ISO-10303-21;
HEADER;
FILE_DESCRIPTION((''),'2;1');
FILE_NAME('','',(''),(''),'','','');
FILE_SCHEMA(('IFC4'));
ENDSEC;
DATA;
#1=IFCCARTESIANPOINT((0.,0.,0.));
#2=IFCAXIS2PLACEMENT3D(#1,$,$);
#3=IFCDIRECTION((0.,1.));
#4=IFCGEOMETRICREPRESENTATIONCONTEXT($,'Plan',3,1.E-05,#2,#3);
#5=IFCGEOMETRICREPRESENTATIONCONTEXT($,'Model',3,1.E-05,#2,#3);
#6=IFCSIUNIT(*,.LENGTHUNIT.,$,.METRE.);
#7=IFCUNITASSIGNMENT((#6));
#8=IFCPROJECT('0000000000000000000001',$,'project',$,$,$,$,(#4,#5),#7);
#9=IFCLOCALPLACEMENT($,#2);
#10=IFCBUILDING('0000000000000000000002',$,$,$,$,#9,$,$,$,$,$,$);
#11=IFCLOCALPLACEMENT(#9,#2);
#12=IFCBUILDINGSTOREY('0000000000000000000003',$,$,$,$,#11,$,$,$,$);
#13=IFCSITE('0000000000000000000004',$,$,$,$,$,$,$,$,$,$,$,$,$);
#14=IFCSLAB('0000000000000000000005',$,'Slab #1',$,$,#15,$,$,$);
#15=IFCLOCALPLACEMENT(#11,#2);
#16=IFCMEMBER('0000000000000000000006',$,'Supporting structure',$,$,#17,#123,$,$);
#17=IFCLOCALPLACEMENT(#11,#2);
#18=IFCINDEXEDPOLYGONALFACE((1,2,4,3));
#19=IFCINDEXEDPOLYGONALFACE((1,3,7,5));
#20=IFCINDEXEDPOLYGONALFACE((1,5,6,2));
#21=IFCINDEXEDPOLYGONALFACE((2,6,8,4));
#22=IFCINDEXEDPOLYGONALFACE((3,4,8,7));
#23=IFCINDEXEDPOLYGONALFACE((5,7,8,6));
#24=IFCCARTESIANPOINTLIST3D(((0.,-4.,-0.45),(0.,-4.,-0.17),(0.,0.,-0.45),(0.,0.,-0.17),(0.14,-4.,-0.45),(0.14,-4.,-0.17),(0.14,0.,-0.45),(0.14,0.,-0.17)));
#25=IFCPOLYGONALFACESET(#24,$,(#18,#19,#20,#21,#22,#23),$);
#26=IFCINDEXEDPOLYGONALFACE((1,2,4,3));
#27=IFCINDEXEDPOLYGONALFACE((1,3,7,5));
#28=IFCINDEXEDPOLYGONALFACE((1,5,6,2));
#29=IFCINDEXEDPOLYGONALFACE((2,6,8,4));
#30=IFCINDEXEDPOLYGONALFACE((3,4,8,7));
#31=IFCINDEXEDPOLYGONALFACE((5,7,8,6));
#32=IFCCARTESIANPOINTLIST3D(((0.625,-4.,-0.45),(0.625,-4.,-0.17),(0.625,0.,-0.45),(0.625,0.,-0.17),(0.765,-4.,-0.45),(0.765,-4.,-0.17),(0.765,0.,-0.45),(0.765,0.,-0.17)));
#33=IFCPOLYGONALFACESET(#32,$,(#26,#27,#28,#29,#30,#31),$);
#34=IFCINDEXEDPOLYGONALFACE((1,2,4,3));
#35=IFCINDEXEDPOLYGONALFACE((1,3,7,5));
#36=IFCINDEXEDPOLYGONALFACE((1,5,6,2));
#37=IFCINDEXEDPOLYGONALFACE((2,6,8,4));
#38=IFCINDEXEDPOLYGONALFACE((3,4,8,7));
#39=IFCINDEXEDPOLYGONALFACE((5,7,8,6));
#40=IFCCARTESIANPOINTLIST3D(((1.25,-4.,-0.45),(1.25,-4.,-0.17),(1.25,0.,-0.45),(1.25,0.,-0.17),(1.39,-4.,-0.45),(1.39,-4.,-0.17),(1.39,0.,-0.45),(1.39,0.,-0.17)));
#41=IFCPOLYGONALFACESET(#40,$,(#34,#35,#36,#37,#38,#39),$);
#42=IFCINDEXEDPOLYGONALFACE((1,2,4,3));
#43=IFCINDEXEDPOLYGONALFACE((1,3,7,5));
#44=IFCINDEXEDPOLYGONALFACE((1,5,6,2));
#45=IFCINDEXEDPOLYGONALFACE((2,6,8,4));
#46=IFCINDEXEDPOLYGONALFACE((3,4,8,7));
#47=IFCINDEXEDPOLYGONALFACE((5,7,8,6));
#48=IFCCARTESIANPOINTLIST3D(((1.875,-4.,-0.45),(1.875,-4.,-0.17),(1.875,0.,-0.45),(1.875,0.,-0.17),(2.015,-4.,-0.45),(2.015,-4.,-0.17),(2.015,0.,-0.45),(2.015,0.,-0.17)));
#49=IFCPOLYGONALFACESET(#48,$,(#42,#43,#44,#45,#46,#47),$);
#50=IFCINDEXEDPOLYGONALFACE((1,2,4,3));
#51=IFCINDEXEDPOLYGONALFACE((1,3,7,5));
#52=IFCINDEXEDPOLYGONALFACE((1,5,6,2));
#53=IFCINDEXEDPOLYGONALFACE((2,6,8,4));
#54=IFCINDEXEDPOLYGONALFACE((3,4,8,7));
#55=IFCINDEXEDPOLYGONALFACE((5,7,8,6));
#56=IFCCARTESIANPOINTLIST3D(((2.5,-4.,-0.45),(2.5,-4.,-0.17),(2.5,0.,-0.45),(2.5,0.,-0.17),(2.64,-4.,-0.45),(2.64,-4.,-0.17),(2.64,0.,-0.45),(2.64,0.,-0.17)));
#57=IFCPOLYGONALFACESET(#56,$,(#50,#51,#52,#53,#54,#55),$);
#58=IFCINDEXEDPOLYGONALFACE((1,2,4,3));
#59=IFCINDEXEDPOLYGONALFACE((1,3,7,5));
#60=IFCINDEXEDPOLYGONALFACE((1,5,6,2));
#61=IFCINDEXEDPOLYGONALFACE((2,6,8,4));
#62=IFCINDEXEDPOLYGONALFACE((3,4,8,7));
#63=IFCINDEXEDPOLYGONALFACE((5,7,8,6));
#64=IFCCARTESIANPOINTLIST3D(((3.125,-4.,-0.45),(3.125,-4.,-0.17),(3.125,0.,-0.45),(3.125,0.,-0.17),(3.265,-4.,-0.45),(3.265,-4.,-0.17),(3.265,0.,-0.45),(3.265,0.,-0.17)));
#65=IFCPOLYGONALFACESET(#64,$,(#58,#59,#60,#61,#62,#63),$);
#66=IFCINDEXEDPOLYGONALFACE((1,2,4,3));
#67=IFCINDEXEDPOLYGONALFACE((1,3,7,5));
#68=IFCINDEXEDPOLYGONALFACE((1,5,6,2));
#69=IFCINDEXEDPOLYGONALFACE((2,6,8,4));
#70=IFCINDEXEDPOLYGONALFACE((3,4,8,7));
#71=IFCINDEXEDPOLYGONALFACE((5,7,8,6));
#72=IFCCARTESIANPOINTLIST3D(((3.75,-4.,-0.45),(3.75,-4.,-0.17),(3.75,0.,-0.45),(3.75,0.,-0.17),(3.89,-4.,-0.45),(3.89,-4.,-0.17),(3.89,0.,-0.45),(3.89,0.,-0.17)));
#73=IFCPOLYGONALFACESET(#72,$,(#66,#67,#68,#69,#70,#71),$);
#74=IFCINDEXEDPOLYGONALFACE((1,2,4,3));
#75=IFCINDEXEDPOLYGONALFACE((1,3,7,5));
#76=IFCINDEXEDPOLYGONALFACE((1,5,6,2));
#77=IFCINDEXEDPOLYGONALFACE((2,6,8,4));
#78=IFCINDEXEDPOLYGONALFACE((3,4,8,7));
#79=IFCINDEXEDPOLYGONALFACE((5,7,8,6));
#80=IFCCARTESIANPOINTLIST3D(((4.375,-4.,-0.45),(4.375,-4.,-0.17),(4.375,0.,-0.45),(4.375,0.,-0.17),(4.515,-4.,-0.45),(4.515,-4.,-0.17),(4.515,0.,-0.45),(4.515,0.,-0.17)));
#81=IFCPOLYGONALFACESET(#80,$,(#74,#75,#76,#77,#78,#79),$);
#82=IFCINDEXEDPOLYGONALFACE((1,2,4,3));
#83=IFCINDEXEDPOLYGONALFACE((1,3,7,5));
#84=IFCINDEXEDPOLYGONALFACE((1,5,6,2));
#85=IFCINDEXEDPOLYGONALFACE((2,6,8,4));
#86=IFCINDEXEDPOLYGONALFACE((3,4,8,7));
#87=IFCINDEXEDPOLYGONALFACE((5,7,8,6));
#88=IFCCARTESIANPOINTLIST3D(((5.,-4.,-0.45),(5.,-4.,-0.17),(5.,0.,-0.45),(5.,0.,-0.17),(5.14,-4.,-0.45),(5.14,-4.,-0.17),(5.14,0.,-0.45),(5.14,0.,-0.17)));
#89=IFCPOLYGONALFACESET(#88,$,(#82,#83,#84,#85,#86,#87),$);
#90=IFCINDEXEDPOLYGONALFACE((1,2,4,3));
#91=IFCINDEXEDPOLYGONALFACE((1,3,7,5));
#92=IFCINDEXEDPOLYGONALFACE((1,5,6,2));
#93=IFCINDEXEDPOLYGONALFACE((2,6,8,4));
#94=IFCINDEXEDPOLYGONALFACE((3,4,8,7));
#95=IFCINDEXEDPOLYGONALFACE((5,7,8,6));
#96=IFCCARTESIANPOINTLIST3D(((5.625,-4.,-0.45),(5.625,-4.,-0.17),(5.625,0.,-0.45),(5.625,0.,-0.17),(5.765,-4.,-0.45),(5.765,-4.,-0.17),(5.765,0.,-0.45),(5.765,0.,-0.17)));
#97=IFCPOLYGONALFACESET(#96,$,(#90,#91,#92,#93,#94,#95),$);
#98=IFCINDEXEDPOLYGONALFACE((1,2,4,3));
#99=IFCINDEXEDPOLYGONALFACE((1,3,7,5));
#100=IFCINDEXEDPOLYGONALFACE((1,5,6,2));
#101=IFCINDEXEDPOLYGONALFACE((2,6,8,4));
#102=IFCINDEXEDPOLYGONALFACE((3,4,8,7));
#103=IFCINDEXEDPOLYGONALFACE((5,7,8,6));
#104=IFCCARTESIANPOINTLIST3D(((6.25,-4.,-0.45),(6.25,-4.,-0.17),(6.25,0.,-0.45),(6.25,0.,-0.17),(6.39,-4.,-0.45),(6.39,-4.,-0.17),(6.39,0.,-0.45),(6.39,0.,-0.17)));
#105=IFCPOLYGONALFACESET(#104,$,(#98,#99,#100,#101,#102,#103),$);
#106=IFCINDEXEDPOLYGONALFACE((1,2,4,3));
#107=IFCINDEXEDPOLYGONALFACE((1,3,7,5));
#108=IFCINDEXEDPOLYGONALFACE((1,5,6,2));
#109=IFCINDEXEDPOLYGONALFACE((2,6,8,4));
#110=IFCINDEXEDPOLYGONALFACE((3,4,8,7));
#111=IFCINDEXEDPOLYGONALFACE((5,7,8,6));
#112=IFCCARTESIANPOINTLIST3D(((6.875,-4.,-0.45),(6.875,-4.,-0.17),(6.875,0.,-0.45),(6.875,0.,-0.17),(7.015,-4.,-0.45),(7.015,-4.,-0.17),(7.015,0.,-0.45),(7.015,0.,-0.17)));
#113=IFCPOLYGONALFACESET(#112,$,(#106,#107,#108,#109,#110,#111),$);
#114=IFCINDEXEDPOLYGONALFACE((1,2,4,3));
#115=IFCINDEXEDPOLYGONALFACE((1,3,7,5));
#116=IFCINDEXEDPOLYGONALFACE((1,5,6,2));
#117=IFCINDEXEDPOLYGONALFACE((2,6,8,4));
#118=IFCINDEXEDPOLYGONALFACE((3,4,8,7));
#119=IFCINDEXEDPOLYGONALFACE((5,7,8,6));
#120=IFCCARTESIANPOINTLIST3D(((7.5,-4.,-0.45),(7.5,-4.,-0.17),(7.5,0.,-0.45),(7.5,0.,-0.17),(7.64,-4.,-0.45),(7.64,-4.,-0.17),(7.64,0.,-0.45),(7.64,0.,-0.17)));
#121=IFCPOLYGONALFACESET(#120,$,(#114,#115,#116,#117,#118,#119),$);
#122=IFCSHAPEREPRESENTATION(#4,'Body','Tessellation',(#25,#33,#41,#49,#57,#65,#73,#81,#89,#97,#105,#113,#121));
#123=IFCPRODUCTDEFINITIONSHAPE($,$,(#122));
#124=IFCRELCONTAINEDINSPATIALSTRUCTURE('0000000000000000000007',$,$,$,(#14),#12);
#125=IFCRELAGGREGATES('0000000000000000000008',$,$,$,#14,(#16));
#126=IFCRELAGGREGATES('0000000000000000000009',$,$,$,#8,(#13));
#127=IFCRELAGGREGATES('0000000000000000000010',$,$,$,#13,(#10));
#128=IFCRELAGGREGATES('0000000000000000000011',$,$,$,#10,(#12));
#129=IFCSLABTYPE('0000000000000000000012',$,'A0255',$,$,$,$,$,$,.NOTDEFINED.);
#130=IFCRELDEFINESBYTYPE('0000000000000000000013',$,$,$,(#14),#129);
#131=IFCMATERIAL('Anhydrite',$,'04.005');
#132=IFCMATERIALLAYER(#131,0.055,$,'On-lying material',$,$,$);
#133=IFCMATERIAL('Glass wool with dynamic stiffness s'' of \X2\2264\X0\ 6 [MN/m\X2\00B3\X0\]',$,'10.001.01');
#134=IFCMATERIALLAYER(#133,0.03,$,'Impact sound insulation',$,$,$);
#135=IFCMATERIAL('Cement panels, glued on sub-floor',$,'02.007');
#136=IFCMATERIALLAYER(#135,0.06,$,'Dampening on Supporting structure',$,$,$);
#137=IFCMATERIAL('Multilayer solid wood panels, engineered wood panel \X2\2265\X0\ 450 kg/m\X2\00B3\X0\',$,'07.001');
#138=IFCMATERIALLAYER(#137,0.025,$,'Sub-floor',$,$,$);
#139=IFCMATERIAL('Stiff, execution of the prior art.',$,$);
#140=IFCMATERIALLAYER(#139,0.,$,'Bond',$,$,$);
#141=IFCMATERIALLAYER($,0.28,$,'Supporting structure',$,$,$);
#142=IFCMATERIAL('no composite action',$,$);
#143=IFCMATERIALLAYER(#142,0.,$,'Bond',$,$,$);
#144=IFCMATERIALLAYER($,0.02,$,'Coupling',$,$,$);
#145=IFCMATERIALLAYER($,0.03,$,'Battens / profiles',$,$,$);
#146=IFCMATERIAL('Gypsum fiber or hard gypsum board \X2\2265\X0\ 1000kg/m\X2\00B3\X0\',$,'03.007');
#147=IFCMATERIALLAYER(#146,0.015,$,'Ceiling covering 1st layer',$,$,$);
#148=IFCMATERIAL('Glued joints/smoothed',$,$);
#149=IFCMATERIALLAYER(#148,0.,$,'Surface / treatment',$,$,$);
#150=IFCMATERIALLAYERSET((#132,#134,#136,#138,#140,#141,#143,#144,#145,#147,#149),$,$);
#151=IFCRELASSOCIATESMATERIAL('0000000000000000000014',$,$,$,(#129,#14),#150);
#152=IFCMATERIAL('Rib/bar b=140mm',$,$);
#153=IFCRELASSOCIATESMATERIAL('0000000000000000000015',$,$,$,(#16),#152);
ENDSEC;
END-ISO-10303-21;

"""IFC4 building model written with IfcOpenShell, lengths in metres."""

from ifc_helpers import new_model, si_unit, direction, frame, frame_2d, origin, place, context, project, spatial, rectangle, extrude, material, layer, layer_set, type_object, element, aggregate, save


model = new_model("IFC4")

# Units and contexts
plan_context = context("Plan", 3, precision=1e-05, world=origin(), true_north=direction((0.0, 1.0)))
model_context = context("Model", 3, precision=1e-05, world=origin(), true_north=direction((0.0, 1.0)))
ifc_project = project(units=[si_unit("LENGTHUNIT", "METRE")], contexts=[plan_context, model_context])

# Site, building, storey
site = spatial("IfcSite", under=ifc_project)
building_placement = place(None, origin())
building = spatial("IfcBuilding", under=site, at=building_placement)
storey_placement = place(building_placement, origin())
storey = spatial("IfcBuildingStorey", under=building, at=storey_placement)

# Slab, member
ifc_material_1 = material(Name="Anhydrite", Category="04.005")
ifc_layer_1 = layer(ifc_material_1, 0.055, Name="On-lying material")
ifc_material_2 = material(Name="Glass wool with dynamic stiffness s' of ≤ 6 [MN/m³]", Category="10.001.01")
ifc_layer_2 = layer(ifc_material_2, 0.03, Name="Impact sound insulation")
ifc_material_3 = material(Name="Cement panels, glued on sub-floor", Category="02.007")
ifc_layer_3 = layer(ifc_material_3, 0.06, Name="Dampening on Supporting structure")
ifc_material_4 = material(Name="Multilayer solid wood panels, engineered wood panel ≥ 450 kg/m³", Category="07.001")
ifc_layer_4 = layer(ifc_material_4, 0.025, Name="Sub-floor")
ifc_material_5 = material(Name="Stiff, execution of the prior art.")
ifc_layer_5 = layer(ifc_material_5, 0.0, Name="Bond")
ifc_layer_6 = layer(None, 0.28, Name="Supporting structure")
ifc_material_6 = material(Name="no composite action")
ifc_layer_7 = layer(ifc_material_6, 0.0, Name="Bond")
ifc_layer_8 = layer(None, 0.02, Name="Coupling")
ifc_layer_9 = layer(None, 0.03, Name="Battens / profiles")
ifc_material_7 = material(Name="Gypsum fiber or hard gypsum board ≥ 1000kg/m³", Category="03.007")
ifc_layer_10 = layer(ifc_material_7, 0.015, Name="Ceiling covering 1st layer")
ifc_material_8 = material(Name="Glued joints/smoothed")
ifc_layer_11 = layer(ifc_material_8, 0.0, Name="Surface / treatment")
ifc_layer_set = layer_set([ifc_layer_1, ifc_layer_2, ifc_layer_3, ifc_layer_4, ifc_layer_5, ifc_layer_6, ifc_layer_7, ifc_layer_8, ifc_layer_9, ifc_layer_10, ifc_layer_11])
slab_type = type_object("IfcSlabType", Name="A0255", PredefinedType="NOTDEFINED", material=ifc_layer_set)
slab_placement = place(None, frame((0.0, 0.0, 0.0), z_axis=(0.0, 0.0, -1.0), x_axis=(1.0, 0.0, 0.0)))
slab = element("IfcSlab", 1, at=slab_placement, inside=storey, type_object=slab_type, material=ifc_layer_set, Name="Slab #1")
ifc_material_9 = material(Name="Rib/bar b=140mm")
member_1_placement = place(slab_placement, origin())
member_1 = element("IfcMember", 2, at=member_1_placement, material=ifc_material_9, Name="Supporting structure", context=plan_context, shape_type="SweptSolid", body=[
    extrude(rectangle(XDim=0.14, YDim=0.28, at=frame_2d((0.07, 0.14), x_axis=(1.0, 0.0))), frame((0.0, 4.0, 0.17), z_axis=(0.0, -1.0, 0.0), x_axis=(1.0, 0.0, 0.0)), (0.0, 0.0, 1.0), 4.0),
    extrude(rectangle(XDim=0.14, YDim=0.28, at=frame_2d((0.07, 0.14), x_axis=(1.0, 0.0))), frame((0.625, 4.0, 0.17), z_axis=(0.0, -1.0, 0.0), x_axis=(1.0, 0.0, 0.0)), (0.0, 0.0, 1.0), 4.0),
    extrude(rectangle(XDim=0.14, YDim=0.28, at=frame_2d((0.07, 0.14), x_axis=(1.0, 0.0))), frame((1.25, 4.0, 0.17), z_axis=(0.0, -1.0, 0.0), x_axis=(1.0, 0.0, 0.0)), (0.0, 0.0, 1.0), 4.0),
    extrude(rectangle(XDim=0.14, YDim=0.28, at=frame_2d((0.07, 0.14), x_axis=(1.0, 0.0))), frame((1.875, 4.0, 0.17), z_axis=(0.0, -1.0, 0.0), x_axis=(1.0, 0.0, 0.0)), (0.0, 0.0, 1.0), 4.0),
    extrude(rectangle(XDim=0.14, YDim=0.28, at=frame_2d((0.07, 0.14), x_axis=(1.0, 0.0))), frame((2.5, 4.0, 0.17), z_axis=(0.0, -1.0, 0.0), x_axis=(1.0, 0.0, 0.0)), (0.0, 0.0, 1.0), 4.0),
    extrude(rectangle(XDim=0.14, YDim=0.28, at=frame_2d((0.07, 0.14), x_axis=(1.0, 0.0))), frame((3.125, 4.0, 0.17), z_axis=(0.0, -1.0, 0.0), x_axis=(1.0, 0.0, 0.0)), (0.0, 0.0, 1.0), 4.0),
    extrude(rectangle(XDim=0.14, YDim=0.28, at=frame_2d((0.07, 0.14), x_axis=(1.0, 0.0))), frame((3.75, 4.0, 0.17), z_axis=(0.0, -1.0, 0.0), x_axis=(1.0, 0.0, 0.0)), (0.0, 0.0, 1.0), 4.0),
    extrude(rectangle(XDim=0.14, YDim=0.28, at=frame_2d((0.07, 0.14), x_axis=(1.0, 0.0))), frame((4.375, 4.0, 0.17), z_axis=(0.0, -1.0, 0.0), x_axis=(1.0, 0.0, 0.0)), (0.0, 0.0, 1.0), 4.0),
    extrude(rectangle(XDim=0.14, YDim=0.28, at=frame_2d((0.07, 0.14), x_axis=(1.0, 0.0))), frame((5.0, 4.0, 0.17), z_axis=(0.0, -1.0, 0.0), x_axis=(1.0, 0.0, 0.0)), (0.0, 0.0, 1.0), 4.0),
    extrude(rectangle(XDim=0.14, YDim=0.28, at=frame_2d((0.07, 0.14), x_axis=(1.0, 0.0))), frame((5.625, 4.0, 0.17), z_axis=(0.0, -1.0, 0.0), x_axis=(1.0, 0.0, 0.0)), (0.0, 0.0, 1.0), 4.0),
    extrude(rectangle(XDim=0.14, YDim=0.28, at=frame_2d((0.07, 0.14), x_axis=(1.0, 0.0))), frame((6.25, 4.0, 0.17), z_axis=(0.0, -1.0, 0.0), x_axis=(1.0, 0.0, 0.0)), (0.0, 0.0, 1.0), 4.0),
    extrude(rectangle(XDim=0.14, YDim=0.28, at=frame_2d((0.07, 0.14), x_axis=(1.0, 0.0))), frame((6.875, 4.0, 0.17), z_axis=(0.0, -1.0, 0.0), x_axis=(1.0, 0.0, 0.0)), (0.0, 0.0, 1.0), 4.0),
    extrude(rectangle(XDim=0.14, YDim=0.28, at=frame_2d((0.07, 0.14), x_axis=(1.0, 0.0))), frame((7.5, 4.0, 0.17), z_axis=(0.0, -1.0, 0.0), x_axis=(1.0, 0.0, 0.0)), (0.0, 0.0, 1.0), 4.0),
])
aggregate(slab, [member_1])

save(model, "model.ifc")
